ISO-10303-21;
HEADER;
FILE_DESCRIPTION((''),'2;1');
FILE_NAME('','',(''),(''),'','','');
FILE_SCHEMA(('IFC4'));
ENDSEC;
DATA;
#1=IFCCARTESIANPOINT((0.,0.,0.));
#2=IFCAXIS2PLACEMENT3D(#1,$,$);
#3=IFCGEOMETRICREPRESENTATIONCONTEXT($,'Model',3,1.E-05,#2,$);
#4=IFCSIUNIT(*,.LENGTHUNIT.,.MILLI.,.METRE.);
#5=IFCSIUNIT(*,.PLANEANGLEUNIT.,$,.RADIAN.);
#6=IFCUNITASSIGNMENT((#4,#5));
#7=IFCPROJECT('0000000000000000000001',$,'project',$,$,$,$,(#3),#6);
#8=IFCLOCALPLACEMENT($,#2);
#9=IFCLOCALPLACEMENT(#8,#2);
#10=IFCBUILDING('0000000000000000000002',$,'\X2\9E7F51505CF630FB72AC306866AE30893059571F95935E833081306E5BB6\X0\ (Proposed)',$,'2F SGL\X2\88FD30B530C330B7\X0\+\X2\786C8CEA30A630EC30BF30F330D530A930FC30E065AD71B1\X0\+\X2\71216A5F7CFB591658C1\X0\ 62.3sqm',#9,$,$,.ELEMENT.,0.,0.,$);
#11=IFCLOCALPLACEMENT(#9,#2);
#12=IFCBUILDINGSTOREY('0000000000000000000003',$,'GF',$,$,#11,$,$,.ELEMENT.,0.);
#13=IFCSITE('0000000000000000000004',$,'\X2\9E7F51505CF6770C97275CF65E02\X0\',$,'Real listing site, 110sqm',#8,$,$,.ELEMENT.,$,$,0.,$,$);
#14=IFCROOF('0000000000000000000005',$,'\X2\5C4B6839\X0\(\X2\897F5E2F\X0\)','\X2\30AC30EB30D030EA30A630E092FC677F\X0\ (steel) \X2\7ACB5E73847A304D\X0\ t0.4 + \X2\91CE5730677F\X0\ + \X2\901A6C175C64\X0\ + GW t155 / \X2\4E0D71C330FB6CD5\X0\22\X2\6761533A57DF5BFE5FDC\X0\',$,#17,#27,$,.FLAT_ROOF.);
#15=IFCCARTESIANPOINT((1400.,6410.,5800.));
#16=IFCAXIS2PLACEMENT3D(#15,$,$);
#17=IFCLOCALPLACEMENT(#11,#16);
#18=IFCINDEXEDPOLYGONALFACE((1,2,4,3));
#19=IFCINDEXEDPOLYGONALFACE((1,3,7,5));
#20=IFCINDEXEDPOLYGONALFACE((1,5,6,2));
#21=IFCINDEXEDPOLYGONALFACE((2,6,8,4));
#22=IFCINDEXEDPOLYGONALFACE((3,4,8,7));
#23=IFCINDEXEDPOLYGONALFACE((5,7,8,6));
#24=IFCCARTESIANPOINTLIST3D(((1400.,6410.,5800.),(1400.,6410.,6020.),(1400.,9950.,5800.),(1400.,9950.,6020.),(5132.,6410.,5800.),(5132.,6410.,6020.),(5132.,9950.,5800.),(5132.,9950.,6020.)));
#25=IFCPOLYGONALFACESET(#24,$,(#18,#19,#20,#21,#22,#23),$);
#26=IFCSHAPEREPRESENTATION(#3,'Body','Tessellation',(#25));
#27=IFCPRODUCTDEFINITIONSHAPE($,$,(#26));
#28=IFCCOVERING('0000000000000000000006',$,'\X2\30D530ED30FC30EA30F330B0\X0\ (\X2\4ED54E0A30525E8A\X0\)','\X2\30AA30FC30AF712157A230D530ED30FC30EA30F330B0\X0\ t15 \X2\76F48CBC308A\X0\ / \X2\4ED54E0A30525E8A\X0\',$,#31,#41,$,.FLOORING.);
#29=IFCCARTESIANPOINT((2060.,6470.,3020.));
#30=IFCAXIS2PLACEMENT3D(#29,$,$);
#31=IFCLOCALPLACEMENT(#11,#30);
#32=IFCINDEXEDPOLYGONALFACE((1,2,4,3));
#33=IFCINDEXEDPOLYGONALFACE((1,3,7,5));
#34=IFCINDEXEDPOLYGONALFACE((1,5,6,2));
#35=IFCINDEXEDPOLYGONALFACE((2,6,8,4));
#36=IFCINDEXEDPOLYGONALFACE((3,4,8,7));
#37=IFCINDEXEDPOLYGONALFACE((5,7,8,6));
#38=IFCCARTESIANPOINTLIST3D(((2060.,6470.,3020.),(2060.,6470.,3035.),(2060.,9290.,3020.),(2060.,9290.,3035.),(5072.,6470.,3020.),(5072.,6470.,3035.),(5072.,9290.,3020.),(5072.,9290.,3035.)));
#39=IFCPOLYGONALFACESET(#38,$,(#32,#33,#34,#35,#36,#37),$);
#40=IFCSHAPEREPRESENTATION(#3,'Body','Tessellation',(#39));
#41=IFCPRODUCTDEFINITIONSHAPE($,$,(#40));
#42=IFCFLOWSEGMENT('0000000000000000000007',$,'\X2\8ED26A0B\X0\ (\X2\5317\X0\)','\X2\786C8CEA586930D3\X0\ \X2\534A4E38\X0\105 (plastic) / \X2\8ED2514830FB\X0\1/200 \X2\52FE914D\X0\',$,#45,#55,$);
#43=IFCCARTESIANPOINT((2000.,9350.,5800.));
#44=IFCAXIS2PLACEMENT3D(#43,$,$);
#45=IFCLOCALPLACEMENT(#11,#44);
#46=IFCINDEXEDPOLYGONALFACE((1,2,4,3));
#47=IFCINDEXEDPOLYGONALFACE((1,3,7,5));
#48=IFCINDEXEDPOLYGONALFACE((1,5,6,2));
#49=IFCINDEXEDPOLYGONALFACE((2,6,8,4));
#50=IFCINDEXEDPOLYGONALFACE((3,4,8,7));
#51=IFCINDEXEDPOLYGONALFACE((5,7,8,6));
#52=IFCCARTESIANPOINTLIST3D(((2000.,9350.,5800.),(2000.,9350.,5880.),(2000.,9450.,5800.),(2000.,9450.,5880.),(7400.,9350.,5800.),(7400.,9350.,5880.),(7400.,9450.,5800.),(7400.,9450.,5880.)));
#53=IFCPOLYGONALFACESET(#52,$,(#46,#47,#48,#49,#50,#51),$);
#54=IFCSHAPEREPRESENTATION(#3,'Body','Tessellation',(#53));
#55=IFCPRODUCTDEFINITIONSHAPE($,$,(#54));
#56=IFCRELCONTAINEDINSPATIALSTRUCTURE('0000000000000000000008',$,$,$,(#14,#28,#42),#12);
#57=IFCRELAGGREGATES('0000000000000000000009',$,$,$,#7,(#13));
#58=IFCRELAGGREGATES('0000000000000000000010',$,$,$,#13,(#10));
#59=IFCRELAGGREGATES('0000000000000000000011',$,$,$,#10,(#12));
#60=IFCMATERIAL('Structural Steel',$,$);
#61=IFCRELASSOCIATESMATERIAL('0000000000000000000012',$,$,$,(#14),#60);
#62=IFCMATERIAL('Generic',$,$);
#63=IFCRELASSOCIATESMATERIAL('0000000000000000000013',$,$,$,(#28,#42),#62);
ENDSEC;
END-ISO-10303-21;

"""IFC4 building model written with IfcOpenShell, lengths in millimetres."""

from ifc_helpers import new_model, si_unit, frame, frame_2d, origin, place, context, project, spatial, rectangle, extrude, material, element, save


model = new_model("IFC4")

# Units and contexts
model_context = context("Model", 3, precision=1e-05, world=origin())
ifc_project = project(units=[si_unit("LENGTHUNIT", "METRE", prefix="MILLI"), si_unit("PLANEANGLEUNIT", "RADIAN")], contexts=[model_context])

# Site, building, storey
site_placement = place(None, origin())
site = spatial("IfcSite", under=ifc_project, at=site_placement, Name="鹿児島県霧島市", ObjectType="Real listing site, 110sqm", CompositionType="ELEMENT", RefElevation=0.0)
building_placement = place(site_placement, origin())
building = spatial("IfcBuilding", under=site, at=building_placement, Name="鹿児島・犬と暮らす土間広めの家 (Proposed)", ObjectType="2F SGL製サッシ+硬質ウレタンフォーム断熱+無機系外壁 62.3sqm", CompositionType="ELEMENT", ElevationOfRefHeight=0.0, ElevationOfTerrain=0.0)
storey_placement = place(building_placement, origin())
storey = spatial("IfcBuildingStorey", under=building, at=storey_placement, Name="GF", CompositionType="ELEMENT", Elevation=0.0)

# Roof
ifc_material_1 = material(Name="Structural Steel")
for number, where, name in (
    (1, (1400.0, 6410.0, 5800.0), "屋根(西帯)"),
):
    element("IfcRoof", number, at=place(storey_placement, frame(where)), inside=storey, material=ifc_material_1, Name=name, Description="ガルバリウム鋼板 (steel) 立平葺き t0.4 + 野地板 + 通気層 + GW t155 / 不燃・法22条区域対応", PredefinedType="FLAT_ROOF", context=model_context, shape_type="SweptSolid", body=[
        extrude(rectangle(XDim=3732.0, YDim=3540.0, at=frame_2d((1866.0, 1770.0))), frame((1400.0, 6410.0, 5800.0)), (0.0, 0.0, 1.0), 220.0),
    ])

# Covering
ifc_material_2 = material(Name="Generic")
covering_placement = place(storey_placement, frame((2060.0, 6470.0, 3020.0)))
element("IfcCovering", 2, at=covering_placement, inside=storey, material=ifc_material_2, Name="フローリング (仕上げ床)", Description="オーク無垢フローリング t15 直貼り / 仕上げ床", PredefinedType="FLOORING", context=model_context, shape_type="SweptSolid", body=[
    extrude(rectangle(XDim=3012.0, YDim=2820.0, at=frame_2d((1506.0, 1410.0))), frame((2060.0, 6470.0, 3020.0)), (0.0, 0.0, 1.0), 15.0),
])

# Flow segment
flow_segment_placement = place(storey_placement, frame((2000.0, 9350.0, 5800.0)))
element("IfcFlowSegment", 3, at=flow_segment_placement, inside=storey, material=ifc_material_2, Name="軒樋 (北)", Description="硬質塩ビ 半丸105 (plastic) / 軒先・1/200 勾配", context=model_context, shape_type="SweptSolid", body=[
    extrude(rectangle(XDim=5400.0, YDim=100.0, at=frame_2d((2700.0, 50.0))), frame((2000.0, 9350.0, 5800.0)), (0.0, 0.0, 1.0), 80.0),
])

save(model, "model.ifc")
